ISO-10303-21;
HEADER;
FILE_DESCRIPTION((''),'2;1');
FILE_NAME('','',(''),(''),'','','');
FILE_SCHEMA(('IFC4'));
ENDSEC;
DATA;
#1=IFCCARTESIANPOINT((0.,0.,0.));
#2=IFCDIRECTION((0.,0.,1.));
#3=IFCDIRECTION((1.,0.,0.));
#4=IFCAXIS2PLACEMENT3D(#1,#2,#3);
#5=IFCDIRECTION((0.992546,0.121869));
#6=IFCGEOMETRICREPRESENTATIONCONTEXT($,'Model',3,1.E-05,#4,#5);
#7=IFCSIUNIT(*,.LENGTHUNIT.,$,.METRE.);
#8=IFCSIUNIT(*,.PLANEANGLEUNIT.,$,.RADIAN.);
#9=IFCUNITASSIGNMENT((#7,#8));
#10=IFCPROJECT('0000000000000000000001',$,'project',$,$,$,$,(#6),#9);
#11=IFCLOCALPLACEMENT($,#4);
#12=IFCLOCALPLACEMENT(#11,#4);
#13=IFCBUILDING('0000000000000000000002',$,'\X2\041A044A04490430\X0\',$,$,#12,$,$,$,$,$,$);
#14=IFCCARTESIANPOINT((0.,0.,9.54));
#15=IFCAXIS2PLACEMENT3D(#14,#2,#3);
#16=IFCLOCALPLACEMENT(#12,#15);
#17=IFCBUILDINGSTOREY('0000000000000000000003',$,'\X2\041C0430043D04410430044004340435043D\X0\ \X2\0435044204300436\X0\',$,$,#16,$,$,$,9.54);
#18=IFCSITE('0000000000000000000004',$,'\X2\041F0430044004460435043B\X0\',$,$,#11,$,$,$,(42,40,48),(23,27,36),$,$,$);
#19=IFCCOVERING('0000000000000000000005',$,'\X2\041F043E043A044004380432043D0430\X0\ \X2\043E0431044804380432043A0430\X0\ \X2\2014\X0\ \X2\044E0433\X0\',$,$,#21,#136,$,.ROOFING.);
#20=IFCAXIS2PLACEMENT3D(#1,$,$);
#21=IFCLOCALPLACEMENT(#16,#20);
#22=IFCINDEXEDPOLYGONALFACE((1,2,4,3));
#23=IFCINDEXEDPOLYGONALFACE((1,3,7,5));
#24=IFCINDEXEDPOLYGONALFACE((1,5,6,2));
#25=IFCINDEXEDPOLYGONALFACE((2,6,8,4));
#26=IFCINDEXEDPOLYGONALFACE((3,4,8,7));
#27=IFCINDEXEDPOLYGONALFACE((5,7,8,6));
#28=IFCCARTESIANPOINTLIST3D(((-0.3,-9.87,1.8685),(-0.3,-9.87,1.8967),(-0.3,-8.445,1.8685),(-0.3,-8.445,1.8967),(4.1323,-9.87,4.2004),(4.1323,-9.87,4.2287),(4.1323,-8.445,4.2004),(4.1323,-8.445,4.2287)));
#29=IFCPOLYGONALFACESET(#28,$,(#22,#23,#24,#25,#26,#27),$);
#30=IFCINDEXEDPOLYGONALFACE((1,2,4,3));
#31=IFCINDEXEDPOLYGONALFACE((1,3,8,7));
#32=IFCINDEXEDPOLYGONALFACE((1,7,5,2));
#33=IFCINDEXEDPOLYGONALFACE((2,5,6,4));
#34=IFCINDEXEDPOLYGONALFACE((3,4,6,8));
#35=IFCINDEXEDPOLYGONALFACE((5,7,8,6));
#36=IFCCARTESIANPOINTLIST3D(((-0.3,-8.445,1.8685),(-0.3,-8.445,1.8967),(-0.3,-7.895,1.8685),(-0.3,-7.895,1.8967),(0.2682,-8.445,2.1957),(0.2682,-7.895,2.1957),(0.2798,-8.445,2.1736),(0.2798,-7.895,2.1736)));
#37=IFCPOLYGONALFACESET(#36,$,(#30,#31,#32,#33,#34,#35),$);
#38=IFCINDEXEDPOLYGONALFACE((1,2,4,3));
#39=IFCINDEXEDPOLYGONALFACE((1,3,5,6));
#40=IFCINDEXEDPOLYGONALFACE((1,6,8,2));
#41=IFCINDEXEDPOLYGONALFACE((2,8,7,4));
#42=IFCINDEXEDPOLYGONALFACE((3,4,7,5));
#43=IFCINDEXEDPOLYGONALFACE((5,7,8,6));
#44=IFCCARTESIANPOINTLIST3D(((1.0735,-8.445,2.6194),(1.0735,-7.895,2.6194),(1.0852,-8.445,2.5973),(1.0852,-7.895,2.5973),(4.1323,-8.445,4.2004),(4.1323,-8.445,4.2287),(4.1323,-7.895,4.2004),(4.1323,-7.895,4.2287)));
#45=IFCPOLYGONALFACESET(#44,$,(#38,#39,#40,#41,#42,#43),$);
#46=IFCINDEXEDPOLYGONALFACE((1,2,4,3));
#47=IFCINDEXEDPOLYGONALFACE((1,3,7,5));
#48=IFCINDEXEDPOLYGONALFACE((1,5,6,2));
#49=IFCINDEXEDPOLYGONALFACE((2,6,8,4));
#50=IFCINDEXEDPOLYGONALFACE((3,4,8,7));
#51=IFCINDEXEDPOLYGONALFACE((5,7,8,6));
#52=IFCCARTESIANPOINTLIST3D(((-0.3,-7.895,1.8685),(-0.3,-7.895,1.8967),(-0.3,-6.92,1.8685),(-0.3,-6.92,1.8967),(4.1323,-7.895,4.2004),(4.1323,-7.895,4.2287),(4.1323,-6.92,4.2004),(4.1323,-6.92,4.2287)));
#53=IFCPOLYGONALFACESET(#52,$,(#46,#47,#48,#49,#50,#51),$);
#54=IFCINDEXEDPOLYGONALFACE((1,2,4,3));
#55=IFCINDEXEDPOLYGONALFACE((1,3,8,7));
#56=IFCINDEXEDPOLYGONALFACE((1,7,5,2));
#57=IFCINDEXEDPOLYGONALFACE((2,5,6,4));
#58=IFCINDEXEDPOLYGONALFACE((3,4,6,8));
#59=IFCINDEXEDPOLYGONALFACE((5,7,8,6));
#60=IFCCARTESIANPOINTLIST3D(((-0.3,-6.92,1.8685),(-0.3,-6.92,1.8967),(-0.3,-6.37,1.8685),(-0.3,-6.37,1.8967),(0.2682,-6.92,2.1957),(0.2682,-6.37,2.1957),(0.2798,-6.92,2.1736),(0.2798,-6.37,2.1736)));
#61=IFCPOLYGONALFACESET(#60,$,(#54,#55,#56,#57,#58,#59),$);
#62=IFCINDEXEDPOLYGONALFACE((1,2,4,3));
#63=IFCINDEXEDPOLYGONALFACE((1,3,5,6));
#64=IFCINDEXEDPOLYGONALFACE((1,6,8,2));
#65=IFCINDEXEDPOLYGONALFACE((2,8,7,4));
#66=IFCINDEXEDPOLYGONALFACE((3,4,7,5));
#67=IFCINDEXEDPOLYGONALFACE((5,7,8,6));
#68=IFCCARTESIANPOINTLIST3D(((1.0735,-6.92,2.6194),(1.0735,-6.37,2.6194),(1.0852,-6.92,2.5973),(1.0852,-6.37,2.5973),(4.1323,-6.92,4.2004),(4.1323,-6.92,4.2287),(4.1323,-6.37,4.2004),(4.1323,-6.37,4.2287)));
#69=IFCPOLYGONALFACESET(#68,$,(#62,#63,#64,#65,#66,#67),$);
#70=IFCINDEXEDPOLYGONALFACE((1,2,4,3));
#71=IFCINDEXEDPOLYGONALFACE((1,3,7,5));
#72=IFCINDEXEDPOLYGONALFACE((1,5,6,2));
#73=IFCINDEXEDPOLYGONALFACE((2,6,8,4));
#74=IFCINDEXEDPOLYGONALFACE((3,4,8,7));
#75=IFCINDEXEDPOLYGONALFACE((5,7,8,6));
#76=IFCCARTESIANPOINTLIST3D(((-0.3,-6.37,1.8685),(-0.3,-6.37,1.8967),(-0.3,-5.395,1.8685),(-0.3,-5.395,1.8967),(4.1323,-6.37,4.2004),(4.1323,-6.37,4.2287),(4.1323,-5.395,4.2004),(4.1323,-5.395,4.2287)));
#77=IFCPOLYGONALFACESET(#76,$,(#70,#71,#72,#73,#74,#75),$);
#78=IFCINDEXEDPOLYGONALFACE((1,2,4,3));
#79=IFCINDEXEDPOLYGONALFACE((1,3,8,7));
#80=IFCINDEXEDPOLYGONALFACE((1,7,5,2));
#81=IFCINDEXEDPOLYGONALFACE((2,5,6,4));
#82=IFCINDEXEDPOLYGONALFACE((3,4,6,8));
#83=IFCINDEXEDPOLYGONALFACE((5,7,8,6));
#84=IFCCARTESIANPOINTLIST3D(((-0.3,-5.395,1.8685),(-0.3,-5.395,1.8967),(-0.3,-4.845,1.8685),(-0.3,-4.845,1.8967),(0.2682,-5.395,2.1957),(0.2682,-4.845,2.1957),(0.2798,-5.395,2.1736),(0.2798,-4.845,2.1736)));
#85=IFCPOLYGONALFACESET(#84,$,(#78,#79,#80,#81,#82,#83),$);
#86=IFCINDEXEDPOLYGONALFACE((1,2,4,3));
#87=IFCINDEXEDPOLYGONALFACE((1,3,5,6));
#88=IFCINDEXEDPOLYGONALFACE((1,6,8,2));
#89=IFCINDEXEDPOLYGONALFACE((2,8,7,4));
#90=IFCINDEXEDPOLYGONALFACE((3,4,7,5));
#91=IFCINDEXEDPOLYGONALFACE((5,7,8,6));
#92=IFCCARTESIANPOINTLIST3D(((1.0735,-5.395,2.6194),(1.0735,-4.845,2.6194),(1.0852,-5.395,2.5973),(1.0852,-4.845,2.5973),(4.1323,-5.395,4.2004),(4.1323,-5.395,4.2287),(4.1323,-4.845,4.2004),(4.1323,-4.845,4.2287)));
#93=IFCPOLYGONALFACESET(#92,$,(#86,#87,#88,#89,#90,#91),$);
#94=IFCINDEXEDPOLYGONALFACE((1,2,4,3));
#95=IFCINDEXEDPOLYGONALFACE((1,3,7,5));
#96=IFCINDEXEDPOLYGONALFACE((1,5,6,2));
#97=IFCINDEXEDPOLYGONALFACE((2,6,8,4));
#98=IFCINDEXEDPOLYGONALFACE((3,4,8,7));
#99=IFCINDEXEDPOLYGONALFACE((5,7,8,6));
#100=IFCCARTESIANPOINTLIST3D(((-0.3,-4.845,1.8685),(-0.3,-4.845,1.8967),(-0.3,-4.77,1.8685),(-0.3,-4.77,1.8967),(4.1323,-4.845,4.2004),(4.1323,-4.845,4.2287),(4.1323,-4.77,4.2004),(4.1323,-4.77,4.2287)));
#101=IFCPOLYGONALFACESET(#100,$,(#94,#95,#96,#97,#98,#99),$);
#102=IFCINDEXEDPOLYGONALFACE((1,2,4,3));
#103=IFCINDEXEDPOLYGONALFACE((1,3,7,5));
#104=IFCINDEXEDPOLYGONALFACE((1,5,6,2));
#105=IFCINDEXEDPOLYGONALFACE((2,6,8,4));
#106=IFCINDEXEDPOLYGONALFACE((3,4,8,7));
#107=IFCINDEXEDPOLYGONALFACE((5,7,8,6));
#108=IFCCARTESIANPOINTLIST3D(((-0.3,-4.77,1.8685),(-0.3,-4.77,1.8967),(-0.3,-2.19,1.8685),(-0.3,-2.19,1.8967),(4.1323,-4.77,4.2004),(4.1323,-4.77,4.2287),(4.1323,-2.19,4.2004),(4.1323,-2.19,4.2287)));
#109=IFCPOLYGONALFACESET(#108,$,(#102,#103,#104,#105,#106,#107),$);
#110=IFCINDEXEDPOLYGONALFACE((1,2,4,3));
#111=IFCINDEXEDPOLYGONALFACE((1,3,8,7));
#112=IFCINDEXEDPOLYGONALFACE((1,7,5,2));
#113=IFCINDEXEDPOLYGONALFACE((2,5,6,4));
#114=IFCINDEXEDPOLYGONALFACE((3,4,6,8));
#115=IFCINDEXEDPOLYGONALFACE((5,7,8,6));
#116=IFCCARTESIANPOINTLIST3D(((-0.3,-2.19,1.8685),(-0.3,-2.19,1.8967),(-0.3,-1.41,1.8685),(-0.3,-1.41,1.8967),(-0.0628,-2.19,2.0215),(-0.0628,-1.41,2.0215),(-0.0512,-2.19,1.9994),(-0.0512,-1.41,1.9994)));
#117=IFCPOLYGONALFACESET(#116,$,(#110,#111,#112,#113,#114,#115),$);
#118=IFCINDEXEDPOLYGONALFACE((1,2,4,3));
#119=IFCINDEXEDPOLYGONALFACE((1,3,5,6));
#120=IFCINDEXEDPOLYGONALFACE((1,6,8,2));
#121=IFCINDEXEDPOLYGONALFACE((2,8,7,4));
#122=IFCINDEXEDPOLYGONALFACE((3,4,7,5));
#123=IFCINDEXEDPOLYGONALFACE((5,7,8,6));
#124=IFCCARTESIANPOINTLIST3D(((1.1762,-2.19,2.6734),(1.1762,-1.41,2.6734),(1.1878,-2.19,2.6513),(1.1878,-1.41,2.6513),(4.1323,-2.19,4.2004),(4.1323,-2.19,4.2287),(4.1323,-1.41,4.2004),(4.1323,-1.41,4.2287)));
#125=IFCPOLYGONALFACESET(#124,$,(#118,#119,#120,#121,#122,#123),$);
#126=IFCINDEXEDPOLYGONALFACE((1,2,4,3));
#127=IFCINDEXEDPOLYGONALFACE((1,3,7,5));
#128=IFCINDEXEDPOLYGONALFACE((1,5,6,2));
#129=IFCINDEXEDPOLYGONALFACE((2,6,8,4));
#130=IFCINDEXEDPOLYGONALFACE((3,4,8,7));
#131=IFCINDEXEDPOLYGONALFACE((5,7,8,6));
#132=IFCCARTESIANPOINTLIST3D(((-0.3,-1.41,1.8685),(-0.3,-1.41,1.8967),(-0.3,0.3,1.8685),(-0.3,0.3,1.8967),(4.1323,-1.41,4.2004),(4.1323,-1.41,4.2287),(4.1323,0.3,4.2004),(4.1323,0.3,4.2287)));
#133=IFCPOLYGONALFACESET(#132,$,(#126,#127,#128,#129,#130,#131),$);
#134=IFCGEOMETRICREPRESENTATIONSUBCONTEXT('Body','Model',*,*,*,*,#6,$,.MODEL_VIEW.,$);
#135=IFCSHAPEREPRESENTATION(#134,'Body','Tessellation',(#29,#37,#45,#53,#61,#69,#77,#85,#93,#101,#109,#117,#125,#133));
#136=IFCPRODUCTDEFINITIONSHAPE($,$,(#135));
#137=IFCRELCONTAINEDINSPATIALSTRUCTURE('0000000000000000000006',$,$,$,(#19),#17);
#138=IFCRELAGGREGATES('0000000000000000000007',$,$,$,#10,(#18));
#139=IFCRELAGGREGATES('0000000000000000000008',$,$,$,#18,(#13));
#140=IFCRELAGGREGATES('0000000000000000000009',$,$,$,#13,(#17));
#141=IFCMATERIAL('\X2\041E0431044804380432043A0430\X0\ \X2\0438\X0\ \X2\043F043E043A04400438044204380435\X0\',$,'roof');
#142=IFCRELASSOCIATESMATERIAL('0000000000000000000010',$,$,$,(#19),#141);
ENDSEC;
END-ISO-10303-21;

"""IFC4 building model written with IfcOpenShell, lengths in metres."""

from ifc_helpers import new_model, si_unit, direction, frame, origin_with_axes, place, context, subcontext, project, spatial, polyline, outline, extrude, material, element, save


model = new_model("IFC4")

# Units and contexts
model_context = context("Model", 3, precision=1e-05, world=origin_with_axes(), true_north=direction((0.992546, 0.121869)))
body_context = subcontext(model_context, "Body", "Model", "MODEL_VIEW")
ifc_project = project(units=[si_unit("LENGTHUNIT", "METRE"), si_unit("PLANEANGLEUNIT", "RADIAN")], contexts=[model_context])

# Site, building, storey
site_placement = place(None, origin_with_axes())
site = spatial("IfcSite", under=ifc_project, at=site_placement, Name="Парцел", RefLatitude=(42, 40, 48), RefLongitude=(23, 27, 36))
building_placement = place(site_placement, origin_with_axes())
building = spatial("IfcBuilding", under=site, at=building_placement, Name="Къща")
storey_placement = place(building_placement, frame((0.0, 0.0, 9.54), z_axis=(0.0, 0.0, 1.0), x_axis=(1.0, 0.0, 0.0)))
storey = spatial("IfcBuildingStorey", under=building, at=storey_placement, Name="Мансарден етаж", Elevation=9.54)

# Covering
ifc_material_1 = material(Name="Обшивка и покритие", Category="roof")
covering_1_placement = place(storey_placement, origin_with_axes())
element("IfcCovering", 1, at=covering_1_placement, inside=storey, material=ifc_material_1, Name="Покривна обшивка — юг", PredefinedType="ROOFING", context=body_context, shape_type="SweptSolid", body=[
    extrude(outline(polyline([(-0.3, -1.8685), (4.1323, -4.2004), (4.1323, -4.2287), (-0.3, -1.8967), (-0.3, -1.8685)])), frame((0.0, -9.87, 0.0), z_axis=(0.0, 1.0, 0.0), x_axis=(1.0, 0.0, 0.0)), (0.0, 0.0, 1.0), 1.425),
    extrude(outline(polyline([(-0.3, -1.8685), (0.2798, -2.1736), (0.2682, -2.1957), (-0.3, -1.8967), (-0.3, -1.8685)])), frame((0.0, -8.445, 0.0), z_axis=(0.0, 1.0, 0.0), x_axis=(1.0, 0.0, 0.0)), (0.0, 0.0, 1.0), 0.55),
    extrude(outline(polyline([(1.0852, -2.5973), (4.1323, -4.2004), (4.1323, -4.2287), (1.0735, -2.6194), (1.0852, -2.5973)])), frame((0.0, -8.445, 0.0), z_axis=(0.0, 1.0, 0.0), x_axis=(1.0, 0.0, 0.0)), (0.0, 0.0, 1.0), 0.55),
    extrude(outline(polyline([(-0.3, -1.8685), (4.1323, -4.2004), (4.1323, -4.2287), (-0.3, -1.8967), (-0.3, -1.8685)])), frame((0.0, -7.895, 0.0), z_axis=(0.0, 1.0, 0.0), x_axis=(1.0, 0.0, 0.0)), (0.0, 0.0, 1.0), 0.975),
    extrude(outline(polyline([(-0.3, -1.8685), (0.2798, -2.1736), (0.2682, -2.1957), (-0.3, -1.8967), (-0.3, -1.8685)])), frame((0.0, -6.92, 0.0), z_axis=(0.0, 1.0, 0.0), x_axis=(1.0, 0.0, 0.0)), (0.0, 0.0, 1.0), 0.55),
    extrude(outline(polyline([(1.0852, -2.5973), (4.1323, -4.2004), (4.1323, -4.2287), (1.0735, -2.6194), (1.0852, -2.5973)])), frame((0.0, -6.92, 0.0), z_axis=(0.0, 1.0, 0.0), x_axis=(1.0, 0.0, 0.0)), (0.0, 0.0, 1.0), 0.55),
    extrude(outline(polyline([(-0.3, -1.8685), (4.1323, -4.2004), (4.1323, -4.2287), (-0.3, -1.8967), (-0.3, -1.8685)])), frame((0.0, -6.37, 0.0), z_axis=(0.0, 1.0, 0.0), x_axis=(1.0, 0.0, 0.0)), (0.0, 0.0, 1.0), 0.975),
    extrude(outline(polyline([(-0.3, -1.8685), (0.2798, -2.1736), (0.2682, -2.1957), (-0.3, -1.8967), (-0.3, -1.8685)])), frame((0.0, -5.395, 0.0), z_axis=(0.0, 1.0, 0.0), x_axis=(1.0, 0.0, 0.0)), (0.0, 0.0, 1.0), 0.55),
    extrude(outline(polyline([(1.0852, -2.5973), (4.1323, -4.2004), (4.1323, -4.2287), (1.0735, -2.6194), (1.0852, -2.5973)])), frame((0.0, -5.395, 0.0), z_axis=(0.0, 1.0, 0.0), x_axis=(1.0, 0.0, 0.0)), (0.0, 0.0, 1.0), 0.55),
    extrude(outline(polyline([(-0.3, -1.8685), (4.1323, -4.2004), (4.1323, -4.2287), (-0.3, -1.8967), (-0.3, -1.8685)])), frame((0.0, -4.845, 0.0), z_axis=(0.0, 1.0, 0.0), x_axis=(1.0, 0.0, 0.0)), (0.0, 0.0, 1.0), 0.075),
    extrude(outline(polyline([(-0.3, -1.8685), (4.1323, -4.2004), (4.1323, -4.2287), (-0.3, -1.8967), (-0.3, -1.8685)])), frame((0.0, -4.77, 0.0), z_axis=(0.0, 1.0, 0.0), x_axis=(1.0, 0.0, 0.0)), (0.0, 0.0, 1.0), 2.58),
    extrude(outline(polyline([(-0.3, -1.8685), (-0.0512, -1.9994), (-0.0628, -2.0215), (-0.3, -1.8967), (-0.3, -1.8685)])), frame((0.0, -2.19, 0.0), z_axis=(0.0, 1.0, 0.0), x_axis=(1.0, 0.0, 0.0)), (0.0, 0.0, 1.0), 0.78),
    extrude(outline(polyline([(1.1878, -2.6513), (4.1323, -4.2004), (4.1323, -4.2287), (1.1762, -2.6734), (1.1878, -2.6513)])), frame((0.0, -2.19, 0.0), z_axis=(0.0, 1.0, 0.0), x_axis=(1.0, 0.0, 0.0)), (0.0, 0.0, 1.0), 0.78),
    extrude(outline(polyline([(-0.3, -1.8685), (4.1323, -4.2004), (4.1323, -4.2287), (-0.3, -1.8967), (-0.3, -1.8685)])), frame((0.0, -1.41, 0.0), z_axis=(0.0, 1.0, 0.0), x_axis=(1.0, 0.0, 0.0)), (0.0, 0.0, 1.0), 1.71),
])

save(model, "model.ifc")
